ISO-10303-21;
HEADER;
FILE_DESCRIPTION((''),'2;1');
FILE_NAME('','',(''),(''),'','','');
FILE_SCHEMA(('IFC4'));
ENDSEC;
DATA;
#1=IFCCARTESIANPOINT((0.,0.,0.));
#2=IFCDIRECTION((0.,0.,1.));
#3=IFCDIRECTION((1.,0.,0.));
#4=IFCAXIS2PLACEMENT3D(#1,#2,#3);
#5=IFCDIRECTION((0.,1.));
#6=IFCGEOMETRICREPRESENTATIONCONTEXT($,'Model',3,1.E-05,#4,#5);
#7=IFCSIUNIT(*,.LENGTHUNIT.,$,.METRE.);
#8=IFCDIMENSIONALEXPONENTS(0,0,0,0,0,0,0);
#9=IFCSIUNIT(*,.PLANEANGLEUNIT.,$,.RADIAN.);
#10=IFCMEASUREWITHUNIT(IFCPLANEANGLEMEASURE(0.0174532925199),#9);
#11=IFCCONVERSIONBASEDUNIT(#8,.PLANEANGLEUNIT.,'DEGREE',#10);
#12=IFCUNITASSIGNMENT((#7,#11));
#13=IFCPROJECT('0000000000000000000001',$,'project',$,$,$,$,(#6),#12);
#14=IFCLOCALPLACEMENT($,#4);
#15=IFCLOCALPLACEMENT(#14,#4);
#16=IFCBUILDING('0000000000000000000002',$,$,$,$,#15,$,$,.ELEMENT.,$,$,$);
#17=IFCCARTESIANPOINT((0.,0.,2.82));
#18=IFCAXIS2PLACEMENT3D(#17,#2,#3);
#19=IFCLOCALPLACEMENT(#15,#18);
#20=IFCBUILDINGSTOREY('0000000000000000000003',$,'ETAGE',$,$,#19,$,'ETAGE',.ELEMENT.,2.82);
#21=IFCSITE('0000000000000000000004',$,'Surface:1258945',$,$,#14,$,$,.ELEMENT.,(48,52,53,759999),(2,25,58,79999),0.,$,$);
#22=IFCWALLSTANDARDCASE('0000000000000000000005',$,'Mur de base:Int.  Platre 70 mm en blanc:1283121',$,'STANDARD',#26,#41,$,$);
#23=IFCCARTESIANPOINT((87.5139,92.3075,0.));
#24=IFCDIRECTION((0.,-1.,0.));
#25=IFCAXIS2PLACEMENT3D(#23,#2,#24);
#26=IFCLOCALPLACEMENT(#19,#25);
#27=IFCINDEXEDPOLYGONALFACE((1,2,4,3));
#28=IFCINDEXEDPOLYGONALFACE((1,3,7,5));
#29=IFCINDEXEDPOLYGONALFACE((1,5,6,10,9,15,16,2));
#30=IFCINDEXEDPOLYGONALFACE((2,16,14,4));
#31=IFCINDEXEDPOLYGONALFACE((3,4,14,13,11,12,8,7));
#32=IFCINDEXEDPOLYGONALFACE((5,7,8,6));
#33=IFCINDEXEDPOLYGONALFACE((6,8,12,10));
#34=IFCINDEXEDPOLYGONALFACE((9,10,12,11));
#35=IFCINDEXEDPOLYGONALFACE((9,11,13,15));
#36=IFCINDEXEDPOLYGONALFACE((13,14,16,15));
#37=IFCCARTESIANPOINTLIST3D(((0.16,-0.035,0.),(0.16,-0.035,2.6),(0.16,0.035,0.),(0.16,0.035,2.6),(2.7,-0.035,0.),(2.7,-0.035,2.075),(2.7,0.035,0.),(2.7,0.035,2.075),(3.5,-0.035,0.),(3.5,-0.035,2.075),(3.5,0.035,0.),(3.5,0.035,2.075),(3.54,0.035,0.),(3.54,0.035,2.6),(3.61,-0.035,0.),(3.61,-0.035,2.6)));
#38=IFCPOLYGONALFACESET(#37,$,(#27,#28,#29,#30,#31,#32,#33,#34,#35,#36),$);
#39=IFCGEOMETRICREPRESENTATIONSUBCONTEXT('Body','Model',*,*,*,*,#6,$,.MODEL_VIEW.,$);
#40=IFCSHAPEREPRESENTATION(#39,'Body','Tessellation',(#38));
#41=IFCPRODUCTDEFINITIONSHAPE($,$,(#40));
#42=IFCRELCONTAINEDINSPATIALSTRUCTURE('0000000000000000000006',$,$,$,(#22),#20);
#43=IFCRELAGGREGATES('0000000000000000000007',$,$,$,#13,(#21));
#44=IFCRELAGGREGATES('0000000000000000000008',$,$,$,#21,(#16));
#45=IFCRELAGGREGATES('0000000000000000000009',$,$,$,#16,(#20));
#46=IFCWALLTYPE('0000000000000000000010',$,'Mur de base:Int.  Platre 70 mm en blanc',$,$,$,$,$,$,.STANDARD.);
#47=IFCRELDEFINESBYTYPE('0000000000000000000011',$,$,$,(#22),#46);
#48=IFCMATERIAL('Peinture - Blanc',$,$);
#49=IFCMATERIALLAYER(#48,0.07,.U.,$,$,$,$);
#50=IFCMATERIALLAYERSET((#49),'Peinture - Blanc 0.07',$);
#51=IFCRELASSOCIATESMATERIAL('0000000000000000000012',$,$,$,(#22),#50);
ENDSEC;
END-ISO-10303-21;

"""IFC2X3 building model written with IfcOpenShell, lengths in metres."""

from ifc_helpers import new_model, entity, si_unit, converted_unit, direction, frame, origin_with_axes, place, context, subcontext, project, spatial, polyline, outline, extrude, material, layer, layer_set, layer_usage, type_object, element, save


model = new_model("IFC2X3")

# Units and contexts
model_context = context("Model", 3, precision=1e-05, world=origin_with_axes(), true_north=direction((0.0, 1.0)))
body_context = subcontext(model_context, "Body", "Model", "MODEL_VIEW")
ifc_project = project(units=[si_unit("LENGTHUNIT", "METRE"), converted_unit("PLANEANGLEUNIT", "DEGREE", entity("IfcPlaneAngleMeasure", 0.0174532925199), si_unit("PLANEANGLEUNIT", "RADIAN"), dimensions=[0, 0, 0, 0, 0, 0, 0])], contexts=[model_context])

# Site, building, storey
site_placement = place(None, origin_with_axes())
site = spatial("IfcSite", under=ifc_project, at=site_placement, Name="Surface:1258945", CompositionType="ELEMENT", RefLatitude=(48, 52, 53, 759999), RefLongitude=(2, 25, 58, 79999), RefElevation=0.0)
building_placement = place(site_placement, origin_with_axes())
building = spatial("IfcBuilding", under=site, at=building_placement, CompositionType="ELEMENT")
storey_placement = place(building_placement, frame((0.0, 0.0, 2.82), z_axis=(0.0, 0.0, 1.0), x_axis=(1.0, 0.0, 0.0)))
storey = spatial("IfcBuildingStorey", under=building, at=storey_placement, Name="ETAGE", LongName="ETAGE", CompositionType="ELEMENT", Elevation=2.82)

# Wall, opening
ifc_material_1 = material(Name="Peinture - Blanc")
ifc_layer_1 = layer(ifc_material_1, 0.07, ventilated="UNKNOWN")
ifc_layer_set_1 = layer_set([ifc_layer_1], Name="Peinture - Blanc 0.07")
wall_type_1 = type_object("IfcWallType", Name="Mur de base:Int.  Platre 70 mm en blanc", PredefinedType="STANDARD")
ifc_layer_usage_1 = layer_usage(ifc_layer_set_1, "AXIS2", "POSITIVE", -0.035)
wall_1_placement = place(storey_placement, frame((87.5139, 92.3075, 0.0), z_axis=(0.0, 0.0, 1.0), x_axis=(0.0, -1.0, 0.0)))
wall_1 = element("IfcWallStandardCase", 1, at=wall_1_placement, inside=storey, type_object=wall_type_1, material=ifc_layer_usage_1, Name="Mur de base:Int.  Platre 70 mm en blanc:1283121", ObjectType="STANDARD", context=body_context, shape_type="SweptSolid", body=[
    extrude(outline(polyline([(0.16, -0.035), (3.61, -0.035), (3.54, 0.035), (0.16, 0.035), (0.16, -0.035)])), origin_with_axes(), (0.0, 0.0, 1.0), 2.6),
])
opening_1_placement = place(wall_1_placement, frame((3.1, 0.0, 0.0), z_axis=(0.0, 0.0, 1.0), x_axis=(1.0, 0.0, 0.0)))
element("IfcOpeningElement", 2, at=opening_1_placement, cuts=wall_1, context=body_context, shape_type="SweptSolid", body=[
    extrude(outline(polyline([(0.4, 0.0), (0.4, 2.075), (-0.4, 2.075), (-0.4, 0.0), (0.4, 0.0)])), frame((0.0, -0.035, 0.0), z_axis=(0.0, 1.0, 0.0), x_axis=(-1.0, 0.0, 0.0)), (0.0, 0.0, 1.0), 0.07),
])

save(model, "model.ifc")
